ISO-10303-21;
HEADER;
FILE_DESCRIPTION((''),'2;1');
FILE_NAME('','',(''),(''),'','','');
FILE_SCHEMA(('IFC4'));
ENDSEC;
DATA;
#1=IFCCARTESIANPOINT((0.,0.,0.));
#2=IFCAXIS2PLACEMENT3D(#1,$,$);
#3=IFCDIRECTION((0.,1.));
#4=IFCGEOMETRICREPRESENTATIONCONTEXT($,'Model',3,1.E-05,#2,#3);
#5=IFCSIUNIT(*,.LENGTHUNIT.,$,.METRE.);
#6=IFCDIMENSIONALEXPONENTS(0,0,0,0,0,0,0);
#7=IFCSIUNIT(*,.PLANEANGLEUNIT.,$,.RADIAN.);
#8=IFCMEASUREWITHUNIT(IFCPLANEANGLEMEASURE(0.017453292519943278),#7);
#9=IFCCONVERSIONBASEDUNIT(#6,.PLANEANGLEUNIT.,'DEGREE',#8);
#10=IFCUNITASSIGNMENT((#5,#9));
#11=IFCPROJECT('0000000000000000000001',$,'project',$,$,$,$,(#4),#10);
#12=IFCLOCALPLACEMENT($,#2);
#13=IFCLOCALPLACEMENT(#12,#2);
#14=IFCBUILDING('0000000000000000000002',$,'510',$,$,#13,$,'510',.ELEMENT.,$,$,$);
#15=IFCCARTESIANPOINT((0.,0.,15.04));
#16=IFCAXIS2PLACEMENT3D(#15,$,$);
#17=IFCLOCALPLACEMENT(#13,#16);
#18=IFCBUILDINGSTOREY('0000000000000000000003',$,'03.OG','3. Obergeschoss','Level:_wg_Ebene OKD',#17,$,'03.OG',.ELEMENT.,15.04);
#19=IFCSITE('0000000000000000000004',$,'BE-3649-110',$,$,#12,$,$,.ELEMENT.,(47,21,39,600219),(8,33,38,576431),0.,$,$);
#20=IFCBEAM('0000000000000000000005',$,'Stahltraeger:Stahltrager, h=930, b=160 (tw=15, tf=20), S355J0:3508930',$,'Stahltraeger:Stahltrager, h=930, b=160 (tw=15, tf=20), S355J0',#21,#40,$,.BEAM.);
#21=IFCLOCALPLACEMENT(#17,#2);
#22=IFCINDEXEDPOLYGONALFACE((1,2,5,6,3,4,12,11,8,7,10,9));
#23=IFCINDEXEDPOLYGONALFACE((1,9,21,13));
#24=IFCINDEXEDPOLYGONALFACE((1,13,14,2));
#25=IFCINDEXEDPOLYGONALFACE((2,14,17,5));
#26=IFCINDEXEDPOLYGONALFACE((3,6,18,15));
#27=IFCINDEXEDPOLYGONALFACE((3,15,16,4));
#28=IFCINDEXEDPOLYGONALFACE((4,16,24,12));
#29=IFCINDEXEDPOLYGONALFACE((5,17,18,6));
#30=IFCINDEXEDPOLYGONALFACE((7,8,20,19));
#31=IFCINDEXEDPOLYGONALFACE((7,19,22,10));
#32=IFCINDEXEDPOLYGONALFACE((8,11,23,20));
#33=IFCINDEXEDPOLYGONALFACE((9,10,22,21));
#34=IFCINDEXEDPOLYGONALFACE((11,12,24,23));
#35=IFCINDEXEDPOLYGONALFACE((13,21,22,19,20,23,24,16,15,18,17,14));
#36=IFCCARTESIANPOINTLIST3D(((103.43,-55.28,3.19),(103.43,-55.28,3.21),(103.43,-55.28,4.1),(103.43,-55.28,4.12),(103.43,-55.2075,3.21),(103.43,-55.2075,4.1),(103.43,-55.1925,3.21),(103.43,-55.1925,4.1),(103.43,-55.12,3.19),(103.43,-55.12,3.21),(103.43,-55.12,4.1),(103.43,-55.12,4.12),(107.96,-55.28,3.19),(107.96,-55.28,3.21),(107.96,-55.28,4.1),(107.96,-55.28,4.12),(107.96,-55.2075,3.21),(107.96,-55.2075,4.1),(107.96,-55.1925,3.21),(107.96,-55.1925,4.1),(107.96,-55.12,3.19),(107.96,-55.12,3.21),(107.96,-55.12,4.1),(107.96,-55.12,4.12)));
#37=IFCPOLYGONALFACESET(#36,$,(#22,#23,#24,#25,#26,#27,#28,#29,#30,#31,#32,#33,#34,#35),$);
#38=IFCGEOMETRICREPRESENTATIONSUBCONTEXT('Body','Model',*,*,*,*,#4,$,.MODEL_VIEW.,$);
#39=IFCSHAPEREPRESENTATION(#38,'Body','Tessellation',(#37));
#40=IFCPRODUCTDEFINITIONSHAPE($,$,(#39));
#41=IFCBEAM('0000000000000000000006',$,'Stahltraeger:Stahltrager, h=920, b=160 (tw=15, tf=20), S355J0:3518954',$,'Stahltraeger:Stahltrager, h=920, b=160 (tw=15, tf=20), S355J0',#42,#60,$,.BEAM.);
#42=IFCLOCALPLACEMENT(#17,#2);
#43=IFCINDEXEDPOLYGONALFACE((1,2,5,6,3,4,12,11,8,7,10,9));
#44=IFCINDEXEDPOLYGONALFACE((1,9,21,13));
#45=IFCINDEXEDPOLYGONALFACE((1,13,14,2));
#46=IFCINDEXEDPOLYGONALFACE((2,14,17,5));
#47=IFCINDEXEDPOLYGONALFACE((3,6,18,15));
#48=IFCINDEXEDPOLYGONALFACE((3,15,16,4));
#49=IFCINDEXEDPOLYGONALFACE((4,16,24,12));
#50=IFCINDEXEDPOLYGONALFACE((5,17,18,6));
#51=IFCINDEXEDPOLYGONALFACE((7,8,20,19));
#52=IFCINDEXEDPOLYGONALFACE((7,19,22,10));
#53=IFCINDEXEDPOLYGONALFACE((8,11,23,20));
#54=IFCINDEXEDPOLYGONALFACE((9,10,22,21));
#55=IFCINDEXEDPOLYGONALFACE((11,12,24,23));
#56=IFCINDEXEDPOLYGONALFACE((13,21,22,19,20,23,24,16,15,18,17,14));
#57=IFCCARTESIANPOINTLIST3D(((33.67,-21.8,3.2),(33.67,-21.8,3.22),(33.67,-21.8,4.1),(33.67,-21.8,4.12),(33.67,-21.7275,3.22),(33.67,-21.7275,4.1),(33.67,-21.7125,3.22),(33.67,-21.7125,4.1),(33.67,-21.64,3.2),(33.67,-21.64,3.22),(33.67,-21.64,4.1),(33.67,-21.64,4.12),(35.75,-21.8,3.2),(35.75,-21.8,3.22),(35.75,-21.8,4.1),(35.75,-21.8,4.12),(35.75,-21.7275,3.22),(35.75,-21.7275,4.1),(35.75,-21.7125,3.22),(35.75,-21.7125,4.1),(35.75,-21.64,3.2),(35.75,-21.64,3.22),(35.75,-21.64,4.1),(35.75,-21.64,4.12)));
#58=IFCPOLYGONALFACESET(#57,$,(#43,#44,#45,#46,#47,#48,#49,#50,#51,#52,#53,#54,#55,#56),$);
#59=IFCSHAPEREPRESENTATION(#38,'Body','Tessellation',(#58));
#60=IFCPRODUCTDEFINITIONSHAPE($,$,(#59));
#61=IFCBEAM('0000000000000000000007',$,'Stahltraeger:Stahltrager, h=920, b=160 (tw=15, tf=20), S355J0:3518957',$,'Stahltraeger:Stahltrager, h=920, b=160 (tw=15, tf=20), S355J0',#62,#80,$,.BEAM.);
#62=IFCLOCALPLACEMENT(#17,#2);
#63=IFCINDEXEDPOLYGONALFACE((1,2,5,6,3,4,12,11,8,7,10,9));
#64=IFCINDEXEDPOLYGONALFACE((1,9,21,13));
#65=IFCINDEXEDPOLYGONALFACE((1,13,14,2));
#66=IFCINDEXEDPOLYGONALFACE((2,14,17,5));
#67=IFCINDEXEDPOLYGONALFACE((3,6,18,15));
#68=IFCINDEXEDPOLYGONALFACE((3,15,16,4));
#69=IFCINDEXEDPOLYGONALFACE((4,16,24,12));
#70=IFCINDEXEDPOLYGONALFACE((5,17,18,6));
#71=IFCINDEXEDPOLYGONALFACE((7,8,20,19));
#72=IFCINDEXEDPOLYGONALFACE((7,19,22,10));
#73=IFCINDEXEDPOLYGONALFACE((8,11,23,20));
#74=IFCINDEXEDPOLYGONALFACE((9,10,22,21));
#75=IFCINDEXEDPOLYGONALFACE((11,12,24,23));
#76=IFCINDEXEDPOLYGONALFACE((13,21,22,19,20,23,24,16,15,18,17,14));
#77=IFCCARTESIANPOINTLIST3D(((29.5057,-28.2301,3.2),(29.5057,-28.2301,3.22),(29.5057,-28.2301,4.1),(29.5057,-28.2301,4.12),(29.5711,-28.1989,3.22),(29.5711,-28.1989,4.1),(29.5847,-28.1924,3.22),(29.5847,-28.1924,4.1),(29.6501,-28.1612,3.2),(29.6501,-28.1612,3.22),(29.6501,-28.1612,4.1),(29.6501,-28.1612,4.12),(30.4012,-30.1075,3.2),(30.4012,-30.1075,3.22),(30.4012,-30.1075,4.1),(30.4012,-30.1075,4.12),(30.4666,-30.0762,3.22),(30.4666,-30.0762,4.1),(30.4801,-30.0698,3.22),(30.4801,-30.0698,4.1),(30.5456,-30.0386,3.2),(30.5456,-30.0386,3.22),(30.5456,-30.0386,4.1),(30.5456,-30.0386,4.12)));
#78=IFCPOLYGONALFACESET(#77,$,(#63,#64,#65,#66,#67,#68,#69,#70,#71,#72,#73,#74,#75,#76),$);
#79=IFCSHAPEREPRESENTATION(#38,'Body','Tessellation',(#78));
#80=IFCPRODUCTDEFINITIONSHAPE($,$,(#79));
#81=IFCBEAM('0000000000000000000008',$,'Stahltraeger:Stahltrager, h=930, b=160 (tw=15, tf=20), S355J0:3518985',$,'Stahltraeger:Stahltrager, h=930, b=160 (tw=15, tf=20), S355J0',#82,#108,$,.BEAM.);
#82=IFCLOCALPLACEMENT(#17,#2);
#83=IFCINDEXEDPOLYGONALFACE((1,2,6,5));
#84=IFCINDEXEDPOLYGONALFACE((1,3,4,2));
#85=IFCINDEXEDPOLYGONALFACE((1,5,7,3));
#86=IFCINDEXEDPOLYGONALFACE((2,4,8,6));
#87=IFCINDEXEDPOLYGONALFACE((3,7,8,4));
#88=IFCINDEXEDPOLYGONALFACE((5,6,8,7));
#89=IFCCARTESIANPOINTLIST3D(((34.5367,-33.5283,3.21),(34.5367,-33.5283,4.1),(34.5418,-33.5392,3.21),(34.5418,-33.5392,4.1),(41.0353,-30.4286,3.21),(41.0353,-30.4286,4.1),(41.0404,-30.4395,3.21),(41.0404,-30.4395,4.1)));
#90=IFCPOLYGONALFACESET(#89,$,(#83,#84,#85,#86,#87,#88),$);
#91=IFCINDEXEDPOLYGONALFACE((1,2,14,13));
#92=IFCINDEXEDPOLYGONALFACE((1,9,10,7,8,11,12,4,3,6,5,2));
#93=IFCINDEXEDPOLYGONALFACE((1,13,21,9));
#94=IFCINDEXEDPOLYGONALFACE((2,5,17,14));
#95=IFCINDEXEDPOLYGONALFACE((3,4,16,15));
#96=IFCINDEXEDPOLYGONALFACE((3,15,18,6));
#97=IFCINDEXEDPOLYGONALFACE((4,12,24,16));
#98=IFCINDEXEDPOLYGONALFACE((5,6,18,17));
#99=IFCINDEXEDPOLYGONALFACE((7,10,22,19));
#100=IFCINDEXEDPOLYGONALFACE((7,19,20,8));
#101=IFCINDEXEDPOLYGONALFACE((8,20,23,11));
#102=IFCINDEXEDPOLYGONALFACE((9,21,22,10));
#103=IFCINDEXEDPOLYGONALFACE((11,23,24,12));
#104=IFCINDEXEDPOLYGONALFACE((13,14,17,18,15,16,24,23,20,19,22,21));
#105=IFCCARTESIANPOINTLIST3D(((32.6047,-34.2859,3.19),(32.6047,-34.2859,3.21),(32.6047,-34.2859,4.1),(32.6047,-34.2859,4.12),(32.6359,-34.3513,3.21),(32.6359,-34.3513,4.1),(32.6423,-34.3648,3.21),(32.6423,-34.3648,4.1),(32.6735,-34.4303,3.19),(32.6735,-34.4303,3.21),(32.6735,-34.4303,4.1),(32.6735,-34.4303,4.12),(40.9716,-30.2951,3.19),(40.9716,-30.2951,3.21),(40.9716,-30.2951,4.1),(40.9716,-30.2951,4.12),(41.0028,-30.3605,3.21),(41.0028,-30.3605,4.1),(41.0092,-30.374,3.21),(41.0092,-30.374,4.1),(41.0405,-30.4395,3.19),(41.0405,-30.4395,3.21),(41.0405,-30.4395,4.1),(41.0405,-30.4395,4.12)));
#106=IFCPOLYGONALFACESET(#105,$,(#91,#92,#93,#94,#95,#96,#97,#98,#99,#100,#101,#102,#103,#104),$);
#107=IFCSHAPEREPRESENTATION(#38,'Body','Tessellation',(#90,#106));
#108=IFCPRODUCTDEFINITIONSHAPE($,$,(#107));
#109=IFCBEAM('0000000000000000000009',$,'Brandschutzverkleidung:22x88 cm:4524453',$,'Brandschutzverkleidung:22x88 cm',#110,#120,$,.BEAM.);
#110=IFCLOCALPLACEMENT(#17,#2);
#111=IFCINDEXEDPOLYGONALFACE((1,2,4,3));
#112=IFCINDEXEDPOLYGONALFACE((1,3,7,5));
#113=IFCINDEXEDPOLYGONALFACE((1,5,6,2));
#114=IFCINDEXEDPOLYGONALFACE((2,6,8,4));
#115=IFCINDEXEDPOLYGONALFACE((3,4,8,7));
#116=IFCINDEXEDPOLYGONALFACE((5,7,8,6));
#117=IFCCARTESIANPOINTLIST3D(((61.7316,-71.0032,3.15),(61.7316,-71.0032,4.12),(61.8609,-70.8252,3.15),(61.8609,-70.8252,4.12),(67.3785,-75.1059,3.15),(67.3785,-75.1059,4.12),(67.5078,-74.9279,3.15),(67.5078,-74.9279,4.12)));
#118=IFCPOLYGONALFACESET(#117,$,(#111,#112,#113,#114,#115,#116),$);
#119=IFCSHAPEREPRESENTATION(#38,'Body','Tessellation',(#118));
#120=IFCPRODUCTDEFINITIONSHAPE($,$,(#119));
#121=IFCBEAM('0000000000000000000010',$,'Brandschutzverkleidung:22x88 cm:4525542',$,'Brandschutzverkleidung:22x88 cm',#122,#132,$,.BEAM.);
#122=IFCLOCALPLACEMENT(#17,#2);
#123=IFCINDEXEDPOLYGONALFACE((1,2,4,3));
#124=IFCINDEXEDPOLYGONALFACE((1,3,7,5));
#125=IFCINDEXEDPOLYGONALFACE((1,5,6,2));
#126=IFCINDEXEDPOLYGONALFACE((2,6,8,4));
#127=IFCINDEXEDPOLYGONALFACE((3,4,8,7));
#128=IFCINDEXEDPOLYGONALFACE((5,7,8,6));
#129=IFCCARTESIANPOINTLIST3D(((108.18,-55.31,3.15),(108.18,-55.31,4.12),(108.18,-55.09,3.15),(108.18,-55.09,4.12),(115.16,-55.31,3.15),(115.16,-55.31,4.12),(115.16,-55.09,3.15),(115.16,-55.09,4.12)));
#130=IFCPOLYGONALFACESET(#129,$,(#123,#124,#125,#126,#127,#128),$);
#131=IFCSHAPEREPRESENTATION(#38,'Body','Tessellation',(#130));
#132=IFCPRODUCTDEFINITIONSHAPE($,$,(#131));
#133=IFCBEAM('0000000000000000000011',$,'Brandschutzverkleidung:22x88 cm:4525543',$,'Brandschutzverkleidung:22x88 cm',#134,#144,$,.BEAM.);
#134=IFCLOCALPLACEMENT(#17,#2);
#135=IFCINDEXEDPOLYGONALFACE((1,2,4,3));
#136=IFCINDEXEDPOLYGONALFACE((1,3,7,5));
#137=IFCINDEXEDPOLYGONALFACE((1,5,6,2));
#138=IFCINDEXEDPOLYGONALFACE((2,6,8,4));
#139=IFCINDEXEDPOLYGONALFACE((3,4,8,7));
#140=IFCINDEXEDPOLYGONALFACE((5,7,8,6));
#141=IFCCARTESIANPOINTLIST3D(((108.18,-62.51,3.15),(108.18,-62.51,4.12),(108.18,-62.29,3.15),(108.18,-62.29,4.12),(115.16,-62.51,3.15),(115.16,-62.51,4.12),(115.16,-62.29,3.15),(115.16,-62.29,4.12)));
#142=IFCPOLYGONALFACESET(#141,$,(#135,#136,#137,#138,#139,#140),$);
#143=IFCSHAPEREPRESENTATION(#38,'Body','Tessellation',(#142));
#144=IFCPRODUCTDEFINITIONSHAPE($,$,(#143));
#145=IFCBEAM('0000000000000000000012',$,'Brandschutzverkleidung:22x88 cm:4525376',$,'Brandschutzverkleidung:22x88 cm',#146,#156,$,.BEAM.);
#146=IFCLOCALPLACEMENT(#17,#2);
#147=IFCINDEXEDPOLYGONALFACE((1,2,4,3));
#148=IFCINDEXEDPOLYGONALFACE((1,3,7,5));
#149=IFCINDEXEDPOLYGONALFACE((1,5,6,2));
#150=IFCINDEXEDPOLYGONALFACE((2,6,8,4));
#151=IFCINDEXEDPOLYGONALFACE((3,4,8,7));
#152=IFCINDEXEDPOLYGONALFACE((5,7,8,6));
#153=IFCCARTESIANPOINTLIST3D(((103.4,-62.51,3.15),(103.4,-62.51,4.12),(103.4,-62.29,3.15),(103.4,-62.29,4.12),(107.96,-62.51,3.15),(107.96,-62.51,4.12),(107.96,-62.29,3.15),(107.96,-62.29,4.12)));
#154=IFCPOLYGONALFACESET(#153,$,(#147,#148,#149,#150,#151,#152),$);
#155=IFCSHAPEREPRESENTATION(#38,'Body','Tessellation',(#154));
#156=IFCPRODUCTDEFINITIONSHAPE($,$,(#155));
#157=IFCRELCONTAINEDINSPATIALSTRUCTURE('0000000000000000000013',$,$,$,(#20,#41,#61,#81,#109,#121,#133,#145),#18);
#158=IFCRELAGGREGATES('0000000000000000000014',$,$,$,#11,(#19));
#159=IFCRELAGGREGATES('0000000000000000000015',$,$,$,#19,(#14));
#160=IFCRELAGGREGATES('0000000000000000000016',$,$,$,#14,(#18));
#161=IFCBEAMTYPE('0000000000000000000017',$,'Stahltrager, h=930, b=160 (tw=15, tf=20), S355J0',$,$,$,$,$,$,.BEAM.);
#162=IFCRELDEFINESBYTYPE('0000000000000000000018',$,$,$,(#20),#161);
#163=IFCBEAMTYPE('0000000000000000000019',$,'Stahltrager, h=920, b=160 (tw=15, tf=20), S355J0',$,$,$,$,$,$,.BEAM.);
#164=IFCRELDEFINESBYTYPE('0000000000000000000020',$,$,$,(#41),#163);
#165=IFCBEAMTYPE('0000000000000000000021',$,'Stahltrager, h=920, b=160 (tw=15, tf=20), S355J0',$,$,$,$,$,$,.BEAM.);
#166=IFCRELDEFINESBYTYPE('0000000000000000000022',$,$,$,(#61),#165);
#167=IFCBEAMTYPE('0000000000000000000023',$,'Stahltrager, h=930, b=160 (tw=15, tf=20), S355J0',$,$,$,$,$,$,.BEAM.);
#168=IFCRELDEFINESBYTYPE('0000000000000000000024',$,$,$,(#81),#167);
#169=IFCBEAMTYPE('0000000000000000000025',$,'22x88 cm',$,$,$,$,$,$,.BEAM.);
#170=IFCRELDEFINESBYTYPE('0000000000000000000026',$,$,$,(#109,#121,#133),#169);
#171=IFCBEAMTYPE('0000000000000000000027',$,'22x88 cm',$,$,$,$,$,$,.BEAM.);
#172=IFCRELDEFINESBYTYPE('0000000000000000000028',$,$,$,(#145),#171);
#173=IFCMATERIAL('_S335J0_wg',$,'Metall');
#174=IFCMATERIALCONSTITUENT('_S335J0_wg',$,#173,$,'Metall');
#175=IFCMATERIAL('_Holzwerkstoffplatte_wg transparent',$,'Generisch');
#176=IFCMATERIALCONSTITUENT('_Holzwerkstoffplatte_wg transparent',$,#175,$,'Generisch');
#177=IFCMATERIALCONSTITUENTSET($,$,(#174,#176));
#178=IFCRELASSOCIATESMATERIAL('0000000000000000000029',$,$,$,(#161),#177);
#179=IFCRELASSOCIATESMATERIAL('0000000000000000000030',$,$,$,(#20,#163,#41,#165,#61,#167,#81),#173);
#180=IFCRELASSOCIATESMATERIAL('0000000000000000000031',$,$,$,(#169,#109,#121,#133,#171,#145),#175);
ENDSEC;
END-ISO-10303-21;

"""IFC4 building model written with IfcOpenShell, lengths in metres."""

from ifc_helpers import new_model, entity, si_unit, converted_unit, direction, frame, origin, place, context, subcontext, project, spatial, indexed_curve, outline, extrude, source, transform, mapped, material, constituent, constituent_set, type_object, type_shapes, element, save


model = new_model("IFC4")

# Units and contexts
model_context = context("Model", 3, precision=1e-05, world=origin(), true_north=direction((0.0, 1.0)))
body_context = subcontext(model_context, "Body", "Model", "MODEL_VIEW")
ifc_project = project(units=[si_unit("LENGTHUNIT", "METRE"), converted_unit("PLANEANGLEUNIT", "DEGREE", entity("IfcPlaneAngleMeasure", 0.017453292519943278), si_unit("PLANEANGLEUNIT", "RADIAN"), dimensions=[0, 0, 0, 0, 0, 0, 0])], contexts=[model_context])

# Site, building, storey
site_placement = place(None, origin())
site = spatial("IfcSite", under=ifc_project, at=site_placement, Name="BE-3649-110", CompositionType="ELEMENT", RefLatitude=(47, 21, 39, 600219), RefLongitude=(8, 33, 38, 576431), RefElevation=0.0)
building_placement = place(site_placement, origin())
building = spatial("IfcBuilding", under=site, at=building_placement, Name="510", LongName="510", CompositionType="ELEMENT")
storey_placement = place(building_placement, frame((0.0, 0.0, 15.04)))
storey = spatial("IfcBuildingStorey", under=building, at=storey_placement, Name="03.OG", Description="3. Obergeschoss", ObjectType="Level:_wg_Ebene OKD", LongName="03.OG", CompositionType="ELEMENT", Elevation=15.04)

# Shared definitions
ifc_material_1 = material(Name="_S335J0_wg", Category="Metall")

# Beam
ifc_material_2 = material(Name="_Holzwerkstoffplatte_wg transparent", Category="Generisch")
ifc_constituent_1 = constituent(ifc_material_1, Name="_S335J0_wg", Category="Metall")
ifc_constituent_2 = constituent(ifc_material_2, Name="_Holzwerkstoffplatte_wg transparent", Category="Generisch")
ifc_constituent_set_1 = constituent_set(constituents=[ifc_constituent_1, ifc_constituent_2])
beam_type_1 = type_object("IfcBeamType", Name="Stahltrager, h=930, b=160 (tw=15, tf=20), S355J0", PredefinedType="BEAM", material=ifc_constituent_set_1)
shared_shape_1 = source(origin(), body_context, "Body", "SweptSolid", [
    extrude(outline(indexed_curve([(-0.465, -0.08), (-0.445, -0.08), (-0.445, -0.0075), (0.445, -0.0075), (0.445, -0.08), (0.465, -0.08), (0.465, 0.08), (0.445, 0.08), (0.445, 0.0075), (-0.445, 0.0075), (-0.445, 0.08), (-0.465, 0.08), (-0.465, -0.08)], self_intersect=False)), frame((-2.265, 0.0, 0.0), z_axis=(1.0, 0.0, 0.0), x_axis=(0.0, 0.0, -1.0)), (0.0, 0.0, 1.0), 4.53),
])
type_shapes(beam_type_1, [shared_shape_1])
beam_1_placement = place(storey_placement, frame((105.695, -55.2, 3.655)))
element("IfcBeam", 1, at=beam_1_placement, inside=storey, type_object=beam_type_1, material=ifc_material_1, Name="Stahltraeger:Stahltrager, h=930, b=160 (tw=15, tf=20), S355J0:3508930", ObjectType="Stahltraeger:Stahltrager, h=930, b=160 (tw=15, tf=20), S355J0", PredefinedType="BEAM", context=body_context, shape_type="MappedRepresentation", body=[
    mapped(shared_shape_1, transform((0.0, 0.0, 0.0), scale=1.0)),
])

# Beams, openings
beam_type_2 = type_object("IfcBeamType", Name="Stahltrager, h=920, b=160 (tw=15, tf=20), S355J0", PredefinedType="BEAM", material=ifc_material_1)
shared_shape_2 = source(origin(), body_context, "Body", "SweptSolid", [
    extrude(outline(indexed_curve([(-0.08, -0.44), (-0.08, -0.46), (0.08, -0.46), (0.08, -0.44), (0.0075, -0.44), (0.0075, 0.44), (0.08, 0.44), (0.08, 0.46), (-0.08, 0.46), (-0.08, 0.44), (-0.0075, 0.44), (-0.0075, -0.44), (-0.08, -0.44)], self_intersect=False)), frame((0.0, 0.08, 0.46), z_axis=(-1.0, 0.0, 0.0), x_axis=(0.0, -1.0, 0.0)), (0.0, 0.0, -1.0), 2.08),
])
type_shapes(beam_type_2, [shared_shape_2])
beam_2_placement = place(storey_placement, frame((33.67, -21.8, 3.2)))
beam_2 = element("IfcBeam", 2, at=beam_2_placement, inside=storey, type_object=beam_type_2, material=ifc_material_1, Name="Stahltraeger:Stahltrager, h=920, b=160 (tw=15, tf=20), S355J0:3518954", ObjectType="Stahltraeger:Stahltrager, h=920, b=160 (tw=15, tf=20), S355J0", PredefinedType="BEAM", context=body_context, shape_type="MappedRepresentation", body=[
    mapped(shared_shape_2, transform((0.0, 0.0, 0.0), scale=1.0)),
])
opening_1_placement = place(storey_placement, frame((33.67, -21.8, 3.2)))
element("IfcOpeningElement", 3, at=opening_1_placement, cuts=beam_2, PredefinedType="OPENING", context=body_context, shape_type="SweptSolid", body=[
    extrude(outline(indexed_curve([(-0.32, -0.22), (0.32, -0.22), (0.32, 0.22), (-0.32, 0.22), (-0.32, -0.22)], self_intersect=False)), frame((1.3687, 0.0875, -14.6), z_axis=(0.0, -1.0, 0.0), x_axis=(1.0, 0.0, 0.0)), (0.0, 0.0, 1.0), 0.015),
])
beam_type_3 = type_object("IfcBeamType", Name="Stahltrager, h=920, b=160 (tw=15, tf=20), S355J0", PredefinedType="BEAM", material=ifc_material_1)
shared_shape_3 = source(origin(), body_context, "Body", "SweptSolid", [
    extrude(outline(indexed_curve([(-0.08, -0.44), (-0.08, -0.46), (0.08, -0.46), (0.08, -0.44), (0.0075, -0.44), (0.0075, 0.44), (0.08, 0.44), (0.08, 0.46), (-0.08, 0.46), (-0.08, 0.44), (-0.0075, 0.44), (-0.0075, -0.44), (-0.08, -0.44)], self_intersect=False)), frame((0.9677, 0.0344, 0.46), z_axis=(0.430511, -0.902585, 0.0), x_axis=(0.902585, 0.430511, 0.0)), (0.0, 0.0, -1.0), 2.08),
])
type_shapes(beam_type_3, [shared_shape_3])
beam_3_placement = place(storey_placement, frame((29.5057, -30.1075, 3.2)))
beam_3 = element("IfcBeam", 4, at=beam_3_placement, inside=storey, type_object=beam_type_3, material=ifc_material_1, Name="Stahltraeger:Stahltrager, h=920, b=160 (tw=15, tf=20), S355J0:3518957", ObjectType="Stahltraeger:Stahltrager, h=920, b=160 (tw=15, tf=20), S355J0", PredefinedType="BEAM", context=body_context, shape_type="MappedRepresentation", body=[
    mapped(shared_shape_3, transform((0.0, 0.0, 0.0), scale=1.0)),
])
opening_2_placement = place(storey_placement, frame((29.5057, -30.1075, 3.2)))
element("IfcOpeningElement", 5, at=opening_2_placement, cuts=beam_3, PredefinedType="OPENING", context=body_context, shape_type="SweptSolid", body=[
    extrude(outline(indexed_curve([(-0.32, -0.22), (0.32, -0.22), (0.32, 0.22), (-0.32, 0.22), (-0.32, -0.22)], self_intersect=False)), frame((0.5267, 0.9764, -14.6), z_axis=(-0.902585, -0.430511, 0.0), x_axis=(0.430511, -0.902585, 0.0)), (0.0, 0.0, 1.0), 0.015),
])
beam_type_4 = type_object("IfcBeamType", Name="Stahltrager, h=930, b=160 (tw=15, tf=20), S355J0", PredefinedType="BEAM", material=ifc_material_1)
shared_shape_4 = source(origin(), body_context, "Body", "SweptSolid", [
    extrude(outline(indexed_curve([(-0.445, -0.006), (0.445, -0.006), (0.445, 0.006), (-0.445, 0.006), (-0.445, -0.006)], self_intersect=False)), frame((1.9346, 0.8965, 0.465), z_axis=(0.902585, 0.430511, 0.0), x_axis=(0.0, 0.0, -1.0)), (0.0, 0.0, 1.0), 7.2),
    extrude(outline(indexed_curve([(0.445, -0.08), (0.465, -0.08), (0.465, 0.08), (0.445, 0.08), (0.445, 0.0075), (-0.445, 0.0075), (-0.445, 0.08), (-0.465, 0.08), (-0.465, -0.08), (-0.445, -0.08), (-0.445, -0.0075), (0.445, -0.0075), (0.445, -0.08)], self_intersect=False)), frame((0.0344, 0.0722, 0.465), z_axis=(0.902585, 0.430511, 0.0), x_axis=(0.0, 0.0, -1.0)), (0.0, 0.0, 1.0), 9.2699),
])
type_shapes(beam_type_4, [shared_shape_4])
beam_4_placement = place(storey_placement, frame((32.6047, -34.4303, 3.19)))
beam_4 = element("IfcBeam", 6, at=beam_4_placement, inside=storey, type_object=beam_type_4, material=ifc_material_1, Name="Stahltraeger:Stahltrager, h=930, b=160 (tw=15, tf=20), S355J0:3518985", ObjectType="Stahltraeger:Stahltrager, h=930, b=160 (tw=15, tf=20), S355J0", PredefinedType="BEAM", context=body_context, shape_type="MappedRepresentation", body=[
    mapped(shared_shape_4, transform((0.0, 0.0, 0.0), scale=1.0)),
])
opening_3_placement = place(storey_placement, frame((32.6047, -34.4303, 3.19)))
element("IfcOpeningElement", 7, at=opening_3_placement, cuts=beam_4, PredefinedType="OPENING", context=body_context, shape_type="SweptSolid", body=[
    extrude(outline(indexed_curve([(-0.225, -0.15), (0.225, -0.15), (0.225, 0.15), (-0.225, 0.15), (-0.225, -0.15)], self_intersect=False)), frame((0.9638, 0.5238, -14.5928), z_axis=(0.430511, -0.902585, 0.0), x_axis=(0.902585, 0.430511, 0.0)), (0.0, 0.0, 1.0), 0.015),
])

# Beams
beam_type_5 = type_object("IfcBeamType", Name="22x88 cm", PredefinedType="BEAM", material=ifc_material_2)
shared_shape_5 = source(origin(), body_context, "Body", "SweptSolid", [
    extrude(outline(indexed_curve([(-3.49, -0.11), (3.49, -0.11), (3.49, 0.11), (-3.49, 0.11), (-3.49, -0.11)], self_intersect=False)), frame((0.0, 0.0, -0.485)), (0.0, 0.0, 1.0), 0.97),
])
type_shapes(beam_type_5, [shared_shape_5])
beam_5_placement = place(storey_placement, frame((64.6197, -72.9655, 3.635), z_axis=(0.0, 0.0, 1.0), x_axis=(0.809017, -0.587785, 0.0)))
element("IfcBeam", 8, at=beam_5_placement, inside=storey, type_object=beam_type_5, material=ifc_material_2, Name="Brandschutzverkleidung:22x88 cm:4524453", ObjectType="Brandschutzverkleidung:22x88 cm", PredefinedType="BEAM", context=body_context, shape_type="MappedRepresentation", body=[
    mapped(shared_shape_5, transform((0.0, 0.0, 0.0), scale=1.0)),
])
for number, where, name in (
    (9, (111.67, -55.2, 3.635), "Brandschutzverkleidung:22x88 cm:4525542"),
    (10, (111.67, -62.4, 3.635), "Brandschutzverkleidung:22x88 cm:4525543"),
):
    element("IfcBeam", number, at=place(storey_placement, frame(where)), inside=storey, type_object=beam_type_5, material=ifc_material_2, Name=name, ObjectType="Brandschutzverkleidung:22x88 cm", PredefinedType="BEAM", context=body_context, shape_type="MappedRepresentation", body=[
        mapped(shared_shape_5, transform((0.0, 0.0, 0.0), scale=1.0)),
    ])
beam_type_6 = type_object("IfcBeamType", Name="22x88 cm", PredefinedType="BEAM", material=ifc_material_2)
shared_shape_6 = source(origin(), body_context, "Body", "SweptSolid", [
    extrude(outline(indexed_curve([(-2.28, -0.11), (2.28, -0.11), (2.28, 0.11), (-2.28, 0.11), (-2.28, -0.11)], self_intersect=False)), frame((0.0, 0.0, -0.485)), (0.0, 0.0, 1.0), 0.97),
])
type_shapes(beam_type_6, [shared_shape_6])
beam_6_placement = place(storey_placement, frame((105.68, -62.4, 3.635)))
element("IfcBeam", 11, at=beam_6_placement, inside=storey, type_object=beam_type_6, material=ifc_material_2, Name="Brandschutzverkleidung:22x88 cm:4525376", ObjectType="Brandschutzverkleidung:22x88 cm", PredefinedType="BEAM", context=body_context, shape_type="MappedRepresentation", body=[
    mapped(shared_shape_6, transform((0.0, 0.0, 0.0), scale=1.0)),
])

save(model, "model.ifc")
